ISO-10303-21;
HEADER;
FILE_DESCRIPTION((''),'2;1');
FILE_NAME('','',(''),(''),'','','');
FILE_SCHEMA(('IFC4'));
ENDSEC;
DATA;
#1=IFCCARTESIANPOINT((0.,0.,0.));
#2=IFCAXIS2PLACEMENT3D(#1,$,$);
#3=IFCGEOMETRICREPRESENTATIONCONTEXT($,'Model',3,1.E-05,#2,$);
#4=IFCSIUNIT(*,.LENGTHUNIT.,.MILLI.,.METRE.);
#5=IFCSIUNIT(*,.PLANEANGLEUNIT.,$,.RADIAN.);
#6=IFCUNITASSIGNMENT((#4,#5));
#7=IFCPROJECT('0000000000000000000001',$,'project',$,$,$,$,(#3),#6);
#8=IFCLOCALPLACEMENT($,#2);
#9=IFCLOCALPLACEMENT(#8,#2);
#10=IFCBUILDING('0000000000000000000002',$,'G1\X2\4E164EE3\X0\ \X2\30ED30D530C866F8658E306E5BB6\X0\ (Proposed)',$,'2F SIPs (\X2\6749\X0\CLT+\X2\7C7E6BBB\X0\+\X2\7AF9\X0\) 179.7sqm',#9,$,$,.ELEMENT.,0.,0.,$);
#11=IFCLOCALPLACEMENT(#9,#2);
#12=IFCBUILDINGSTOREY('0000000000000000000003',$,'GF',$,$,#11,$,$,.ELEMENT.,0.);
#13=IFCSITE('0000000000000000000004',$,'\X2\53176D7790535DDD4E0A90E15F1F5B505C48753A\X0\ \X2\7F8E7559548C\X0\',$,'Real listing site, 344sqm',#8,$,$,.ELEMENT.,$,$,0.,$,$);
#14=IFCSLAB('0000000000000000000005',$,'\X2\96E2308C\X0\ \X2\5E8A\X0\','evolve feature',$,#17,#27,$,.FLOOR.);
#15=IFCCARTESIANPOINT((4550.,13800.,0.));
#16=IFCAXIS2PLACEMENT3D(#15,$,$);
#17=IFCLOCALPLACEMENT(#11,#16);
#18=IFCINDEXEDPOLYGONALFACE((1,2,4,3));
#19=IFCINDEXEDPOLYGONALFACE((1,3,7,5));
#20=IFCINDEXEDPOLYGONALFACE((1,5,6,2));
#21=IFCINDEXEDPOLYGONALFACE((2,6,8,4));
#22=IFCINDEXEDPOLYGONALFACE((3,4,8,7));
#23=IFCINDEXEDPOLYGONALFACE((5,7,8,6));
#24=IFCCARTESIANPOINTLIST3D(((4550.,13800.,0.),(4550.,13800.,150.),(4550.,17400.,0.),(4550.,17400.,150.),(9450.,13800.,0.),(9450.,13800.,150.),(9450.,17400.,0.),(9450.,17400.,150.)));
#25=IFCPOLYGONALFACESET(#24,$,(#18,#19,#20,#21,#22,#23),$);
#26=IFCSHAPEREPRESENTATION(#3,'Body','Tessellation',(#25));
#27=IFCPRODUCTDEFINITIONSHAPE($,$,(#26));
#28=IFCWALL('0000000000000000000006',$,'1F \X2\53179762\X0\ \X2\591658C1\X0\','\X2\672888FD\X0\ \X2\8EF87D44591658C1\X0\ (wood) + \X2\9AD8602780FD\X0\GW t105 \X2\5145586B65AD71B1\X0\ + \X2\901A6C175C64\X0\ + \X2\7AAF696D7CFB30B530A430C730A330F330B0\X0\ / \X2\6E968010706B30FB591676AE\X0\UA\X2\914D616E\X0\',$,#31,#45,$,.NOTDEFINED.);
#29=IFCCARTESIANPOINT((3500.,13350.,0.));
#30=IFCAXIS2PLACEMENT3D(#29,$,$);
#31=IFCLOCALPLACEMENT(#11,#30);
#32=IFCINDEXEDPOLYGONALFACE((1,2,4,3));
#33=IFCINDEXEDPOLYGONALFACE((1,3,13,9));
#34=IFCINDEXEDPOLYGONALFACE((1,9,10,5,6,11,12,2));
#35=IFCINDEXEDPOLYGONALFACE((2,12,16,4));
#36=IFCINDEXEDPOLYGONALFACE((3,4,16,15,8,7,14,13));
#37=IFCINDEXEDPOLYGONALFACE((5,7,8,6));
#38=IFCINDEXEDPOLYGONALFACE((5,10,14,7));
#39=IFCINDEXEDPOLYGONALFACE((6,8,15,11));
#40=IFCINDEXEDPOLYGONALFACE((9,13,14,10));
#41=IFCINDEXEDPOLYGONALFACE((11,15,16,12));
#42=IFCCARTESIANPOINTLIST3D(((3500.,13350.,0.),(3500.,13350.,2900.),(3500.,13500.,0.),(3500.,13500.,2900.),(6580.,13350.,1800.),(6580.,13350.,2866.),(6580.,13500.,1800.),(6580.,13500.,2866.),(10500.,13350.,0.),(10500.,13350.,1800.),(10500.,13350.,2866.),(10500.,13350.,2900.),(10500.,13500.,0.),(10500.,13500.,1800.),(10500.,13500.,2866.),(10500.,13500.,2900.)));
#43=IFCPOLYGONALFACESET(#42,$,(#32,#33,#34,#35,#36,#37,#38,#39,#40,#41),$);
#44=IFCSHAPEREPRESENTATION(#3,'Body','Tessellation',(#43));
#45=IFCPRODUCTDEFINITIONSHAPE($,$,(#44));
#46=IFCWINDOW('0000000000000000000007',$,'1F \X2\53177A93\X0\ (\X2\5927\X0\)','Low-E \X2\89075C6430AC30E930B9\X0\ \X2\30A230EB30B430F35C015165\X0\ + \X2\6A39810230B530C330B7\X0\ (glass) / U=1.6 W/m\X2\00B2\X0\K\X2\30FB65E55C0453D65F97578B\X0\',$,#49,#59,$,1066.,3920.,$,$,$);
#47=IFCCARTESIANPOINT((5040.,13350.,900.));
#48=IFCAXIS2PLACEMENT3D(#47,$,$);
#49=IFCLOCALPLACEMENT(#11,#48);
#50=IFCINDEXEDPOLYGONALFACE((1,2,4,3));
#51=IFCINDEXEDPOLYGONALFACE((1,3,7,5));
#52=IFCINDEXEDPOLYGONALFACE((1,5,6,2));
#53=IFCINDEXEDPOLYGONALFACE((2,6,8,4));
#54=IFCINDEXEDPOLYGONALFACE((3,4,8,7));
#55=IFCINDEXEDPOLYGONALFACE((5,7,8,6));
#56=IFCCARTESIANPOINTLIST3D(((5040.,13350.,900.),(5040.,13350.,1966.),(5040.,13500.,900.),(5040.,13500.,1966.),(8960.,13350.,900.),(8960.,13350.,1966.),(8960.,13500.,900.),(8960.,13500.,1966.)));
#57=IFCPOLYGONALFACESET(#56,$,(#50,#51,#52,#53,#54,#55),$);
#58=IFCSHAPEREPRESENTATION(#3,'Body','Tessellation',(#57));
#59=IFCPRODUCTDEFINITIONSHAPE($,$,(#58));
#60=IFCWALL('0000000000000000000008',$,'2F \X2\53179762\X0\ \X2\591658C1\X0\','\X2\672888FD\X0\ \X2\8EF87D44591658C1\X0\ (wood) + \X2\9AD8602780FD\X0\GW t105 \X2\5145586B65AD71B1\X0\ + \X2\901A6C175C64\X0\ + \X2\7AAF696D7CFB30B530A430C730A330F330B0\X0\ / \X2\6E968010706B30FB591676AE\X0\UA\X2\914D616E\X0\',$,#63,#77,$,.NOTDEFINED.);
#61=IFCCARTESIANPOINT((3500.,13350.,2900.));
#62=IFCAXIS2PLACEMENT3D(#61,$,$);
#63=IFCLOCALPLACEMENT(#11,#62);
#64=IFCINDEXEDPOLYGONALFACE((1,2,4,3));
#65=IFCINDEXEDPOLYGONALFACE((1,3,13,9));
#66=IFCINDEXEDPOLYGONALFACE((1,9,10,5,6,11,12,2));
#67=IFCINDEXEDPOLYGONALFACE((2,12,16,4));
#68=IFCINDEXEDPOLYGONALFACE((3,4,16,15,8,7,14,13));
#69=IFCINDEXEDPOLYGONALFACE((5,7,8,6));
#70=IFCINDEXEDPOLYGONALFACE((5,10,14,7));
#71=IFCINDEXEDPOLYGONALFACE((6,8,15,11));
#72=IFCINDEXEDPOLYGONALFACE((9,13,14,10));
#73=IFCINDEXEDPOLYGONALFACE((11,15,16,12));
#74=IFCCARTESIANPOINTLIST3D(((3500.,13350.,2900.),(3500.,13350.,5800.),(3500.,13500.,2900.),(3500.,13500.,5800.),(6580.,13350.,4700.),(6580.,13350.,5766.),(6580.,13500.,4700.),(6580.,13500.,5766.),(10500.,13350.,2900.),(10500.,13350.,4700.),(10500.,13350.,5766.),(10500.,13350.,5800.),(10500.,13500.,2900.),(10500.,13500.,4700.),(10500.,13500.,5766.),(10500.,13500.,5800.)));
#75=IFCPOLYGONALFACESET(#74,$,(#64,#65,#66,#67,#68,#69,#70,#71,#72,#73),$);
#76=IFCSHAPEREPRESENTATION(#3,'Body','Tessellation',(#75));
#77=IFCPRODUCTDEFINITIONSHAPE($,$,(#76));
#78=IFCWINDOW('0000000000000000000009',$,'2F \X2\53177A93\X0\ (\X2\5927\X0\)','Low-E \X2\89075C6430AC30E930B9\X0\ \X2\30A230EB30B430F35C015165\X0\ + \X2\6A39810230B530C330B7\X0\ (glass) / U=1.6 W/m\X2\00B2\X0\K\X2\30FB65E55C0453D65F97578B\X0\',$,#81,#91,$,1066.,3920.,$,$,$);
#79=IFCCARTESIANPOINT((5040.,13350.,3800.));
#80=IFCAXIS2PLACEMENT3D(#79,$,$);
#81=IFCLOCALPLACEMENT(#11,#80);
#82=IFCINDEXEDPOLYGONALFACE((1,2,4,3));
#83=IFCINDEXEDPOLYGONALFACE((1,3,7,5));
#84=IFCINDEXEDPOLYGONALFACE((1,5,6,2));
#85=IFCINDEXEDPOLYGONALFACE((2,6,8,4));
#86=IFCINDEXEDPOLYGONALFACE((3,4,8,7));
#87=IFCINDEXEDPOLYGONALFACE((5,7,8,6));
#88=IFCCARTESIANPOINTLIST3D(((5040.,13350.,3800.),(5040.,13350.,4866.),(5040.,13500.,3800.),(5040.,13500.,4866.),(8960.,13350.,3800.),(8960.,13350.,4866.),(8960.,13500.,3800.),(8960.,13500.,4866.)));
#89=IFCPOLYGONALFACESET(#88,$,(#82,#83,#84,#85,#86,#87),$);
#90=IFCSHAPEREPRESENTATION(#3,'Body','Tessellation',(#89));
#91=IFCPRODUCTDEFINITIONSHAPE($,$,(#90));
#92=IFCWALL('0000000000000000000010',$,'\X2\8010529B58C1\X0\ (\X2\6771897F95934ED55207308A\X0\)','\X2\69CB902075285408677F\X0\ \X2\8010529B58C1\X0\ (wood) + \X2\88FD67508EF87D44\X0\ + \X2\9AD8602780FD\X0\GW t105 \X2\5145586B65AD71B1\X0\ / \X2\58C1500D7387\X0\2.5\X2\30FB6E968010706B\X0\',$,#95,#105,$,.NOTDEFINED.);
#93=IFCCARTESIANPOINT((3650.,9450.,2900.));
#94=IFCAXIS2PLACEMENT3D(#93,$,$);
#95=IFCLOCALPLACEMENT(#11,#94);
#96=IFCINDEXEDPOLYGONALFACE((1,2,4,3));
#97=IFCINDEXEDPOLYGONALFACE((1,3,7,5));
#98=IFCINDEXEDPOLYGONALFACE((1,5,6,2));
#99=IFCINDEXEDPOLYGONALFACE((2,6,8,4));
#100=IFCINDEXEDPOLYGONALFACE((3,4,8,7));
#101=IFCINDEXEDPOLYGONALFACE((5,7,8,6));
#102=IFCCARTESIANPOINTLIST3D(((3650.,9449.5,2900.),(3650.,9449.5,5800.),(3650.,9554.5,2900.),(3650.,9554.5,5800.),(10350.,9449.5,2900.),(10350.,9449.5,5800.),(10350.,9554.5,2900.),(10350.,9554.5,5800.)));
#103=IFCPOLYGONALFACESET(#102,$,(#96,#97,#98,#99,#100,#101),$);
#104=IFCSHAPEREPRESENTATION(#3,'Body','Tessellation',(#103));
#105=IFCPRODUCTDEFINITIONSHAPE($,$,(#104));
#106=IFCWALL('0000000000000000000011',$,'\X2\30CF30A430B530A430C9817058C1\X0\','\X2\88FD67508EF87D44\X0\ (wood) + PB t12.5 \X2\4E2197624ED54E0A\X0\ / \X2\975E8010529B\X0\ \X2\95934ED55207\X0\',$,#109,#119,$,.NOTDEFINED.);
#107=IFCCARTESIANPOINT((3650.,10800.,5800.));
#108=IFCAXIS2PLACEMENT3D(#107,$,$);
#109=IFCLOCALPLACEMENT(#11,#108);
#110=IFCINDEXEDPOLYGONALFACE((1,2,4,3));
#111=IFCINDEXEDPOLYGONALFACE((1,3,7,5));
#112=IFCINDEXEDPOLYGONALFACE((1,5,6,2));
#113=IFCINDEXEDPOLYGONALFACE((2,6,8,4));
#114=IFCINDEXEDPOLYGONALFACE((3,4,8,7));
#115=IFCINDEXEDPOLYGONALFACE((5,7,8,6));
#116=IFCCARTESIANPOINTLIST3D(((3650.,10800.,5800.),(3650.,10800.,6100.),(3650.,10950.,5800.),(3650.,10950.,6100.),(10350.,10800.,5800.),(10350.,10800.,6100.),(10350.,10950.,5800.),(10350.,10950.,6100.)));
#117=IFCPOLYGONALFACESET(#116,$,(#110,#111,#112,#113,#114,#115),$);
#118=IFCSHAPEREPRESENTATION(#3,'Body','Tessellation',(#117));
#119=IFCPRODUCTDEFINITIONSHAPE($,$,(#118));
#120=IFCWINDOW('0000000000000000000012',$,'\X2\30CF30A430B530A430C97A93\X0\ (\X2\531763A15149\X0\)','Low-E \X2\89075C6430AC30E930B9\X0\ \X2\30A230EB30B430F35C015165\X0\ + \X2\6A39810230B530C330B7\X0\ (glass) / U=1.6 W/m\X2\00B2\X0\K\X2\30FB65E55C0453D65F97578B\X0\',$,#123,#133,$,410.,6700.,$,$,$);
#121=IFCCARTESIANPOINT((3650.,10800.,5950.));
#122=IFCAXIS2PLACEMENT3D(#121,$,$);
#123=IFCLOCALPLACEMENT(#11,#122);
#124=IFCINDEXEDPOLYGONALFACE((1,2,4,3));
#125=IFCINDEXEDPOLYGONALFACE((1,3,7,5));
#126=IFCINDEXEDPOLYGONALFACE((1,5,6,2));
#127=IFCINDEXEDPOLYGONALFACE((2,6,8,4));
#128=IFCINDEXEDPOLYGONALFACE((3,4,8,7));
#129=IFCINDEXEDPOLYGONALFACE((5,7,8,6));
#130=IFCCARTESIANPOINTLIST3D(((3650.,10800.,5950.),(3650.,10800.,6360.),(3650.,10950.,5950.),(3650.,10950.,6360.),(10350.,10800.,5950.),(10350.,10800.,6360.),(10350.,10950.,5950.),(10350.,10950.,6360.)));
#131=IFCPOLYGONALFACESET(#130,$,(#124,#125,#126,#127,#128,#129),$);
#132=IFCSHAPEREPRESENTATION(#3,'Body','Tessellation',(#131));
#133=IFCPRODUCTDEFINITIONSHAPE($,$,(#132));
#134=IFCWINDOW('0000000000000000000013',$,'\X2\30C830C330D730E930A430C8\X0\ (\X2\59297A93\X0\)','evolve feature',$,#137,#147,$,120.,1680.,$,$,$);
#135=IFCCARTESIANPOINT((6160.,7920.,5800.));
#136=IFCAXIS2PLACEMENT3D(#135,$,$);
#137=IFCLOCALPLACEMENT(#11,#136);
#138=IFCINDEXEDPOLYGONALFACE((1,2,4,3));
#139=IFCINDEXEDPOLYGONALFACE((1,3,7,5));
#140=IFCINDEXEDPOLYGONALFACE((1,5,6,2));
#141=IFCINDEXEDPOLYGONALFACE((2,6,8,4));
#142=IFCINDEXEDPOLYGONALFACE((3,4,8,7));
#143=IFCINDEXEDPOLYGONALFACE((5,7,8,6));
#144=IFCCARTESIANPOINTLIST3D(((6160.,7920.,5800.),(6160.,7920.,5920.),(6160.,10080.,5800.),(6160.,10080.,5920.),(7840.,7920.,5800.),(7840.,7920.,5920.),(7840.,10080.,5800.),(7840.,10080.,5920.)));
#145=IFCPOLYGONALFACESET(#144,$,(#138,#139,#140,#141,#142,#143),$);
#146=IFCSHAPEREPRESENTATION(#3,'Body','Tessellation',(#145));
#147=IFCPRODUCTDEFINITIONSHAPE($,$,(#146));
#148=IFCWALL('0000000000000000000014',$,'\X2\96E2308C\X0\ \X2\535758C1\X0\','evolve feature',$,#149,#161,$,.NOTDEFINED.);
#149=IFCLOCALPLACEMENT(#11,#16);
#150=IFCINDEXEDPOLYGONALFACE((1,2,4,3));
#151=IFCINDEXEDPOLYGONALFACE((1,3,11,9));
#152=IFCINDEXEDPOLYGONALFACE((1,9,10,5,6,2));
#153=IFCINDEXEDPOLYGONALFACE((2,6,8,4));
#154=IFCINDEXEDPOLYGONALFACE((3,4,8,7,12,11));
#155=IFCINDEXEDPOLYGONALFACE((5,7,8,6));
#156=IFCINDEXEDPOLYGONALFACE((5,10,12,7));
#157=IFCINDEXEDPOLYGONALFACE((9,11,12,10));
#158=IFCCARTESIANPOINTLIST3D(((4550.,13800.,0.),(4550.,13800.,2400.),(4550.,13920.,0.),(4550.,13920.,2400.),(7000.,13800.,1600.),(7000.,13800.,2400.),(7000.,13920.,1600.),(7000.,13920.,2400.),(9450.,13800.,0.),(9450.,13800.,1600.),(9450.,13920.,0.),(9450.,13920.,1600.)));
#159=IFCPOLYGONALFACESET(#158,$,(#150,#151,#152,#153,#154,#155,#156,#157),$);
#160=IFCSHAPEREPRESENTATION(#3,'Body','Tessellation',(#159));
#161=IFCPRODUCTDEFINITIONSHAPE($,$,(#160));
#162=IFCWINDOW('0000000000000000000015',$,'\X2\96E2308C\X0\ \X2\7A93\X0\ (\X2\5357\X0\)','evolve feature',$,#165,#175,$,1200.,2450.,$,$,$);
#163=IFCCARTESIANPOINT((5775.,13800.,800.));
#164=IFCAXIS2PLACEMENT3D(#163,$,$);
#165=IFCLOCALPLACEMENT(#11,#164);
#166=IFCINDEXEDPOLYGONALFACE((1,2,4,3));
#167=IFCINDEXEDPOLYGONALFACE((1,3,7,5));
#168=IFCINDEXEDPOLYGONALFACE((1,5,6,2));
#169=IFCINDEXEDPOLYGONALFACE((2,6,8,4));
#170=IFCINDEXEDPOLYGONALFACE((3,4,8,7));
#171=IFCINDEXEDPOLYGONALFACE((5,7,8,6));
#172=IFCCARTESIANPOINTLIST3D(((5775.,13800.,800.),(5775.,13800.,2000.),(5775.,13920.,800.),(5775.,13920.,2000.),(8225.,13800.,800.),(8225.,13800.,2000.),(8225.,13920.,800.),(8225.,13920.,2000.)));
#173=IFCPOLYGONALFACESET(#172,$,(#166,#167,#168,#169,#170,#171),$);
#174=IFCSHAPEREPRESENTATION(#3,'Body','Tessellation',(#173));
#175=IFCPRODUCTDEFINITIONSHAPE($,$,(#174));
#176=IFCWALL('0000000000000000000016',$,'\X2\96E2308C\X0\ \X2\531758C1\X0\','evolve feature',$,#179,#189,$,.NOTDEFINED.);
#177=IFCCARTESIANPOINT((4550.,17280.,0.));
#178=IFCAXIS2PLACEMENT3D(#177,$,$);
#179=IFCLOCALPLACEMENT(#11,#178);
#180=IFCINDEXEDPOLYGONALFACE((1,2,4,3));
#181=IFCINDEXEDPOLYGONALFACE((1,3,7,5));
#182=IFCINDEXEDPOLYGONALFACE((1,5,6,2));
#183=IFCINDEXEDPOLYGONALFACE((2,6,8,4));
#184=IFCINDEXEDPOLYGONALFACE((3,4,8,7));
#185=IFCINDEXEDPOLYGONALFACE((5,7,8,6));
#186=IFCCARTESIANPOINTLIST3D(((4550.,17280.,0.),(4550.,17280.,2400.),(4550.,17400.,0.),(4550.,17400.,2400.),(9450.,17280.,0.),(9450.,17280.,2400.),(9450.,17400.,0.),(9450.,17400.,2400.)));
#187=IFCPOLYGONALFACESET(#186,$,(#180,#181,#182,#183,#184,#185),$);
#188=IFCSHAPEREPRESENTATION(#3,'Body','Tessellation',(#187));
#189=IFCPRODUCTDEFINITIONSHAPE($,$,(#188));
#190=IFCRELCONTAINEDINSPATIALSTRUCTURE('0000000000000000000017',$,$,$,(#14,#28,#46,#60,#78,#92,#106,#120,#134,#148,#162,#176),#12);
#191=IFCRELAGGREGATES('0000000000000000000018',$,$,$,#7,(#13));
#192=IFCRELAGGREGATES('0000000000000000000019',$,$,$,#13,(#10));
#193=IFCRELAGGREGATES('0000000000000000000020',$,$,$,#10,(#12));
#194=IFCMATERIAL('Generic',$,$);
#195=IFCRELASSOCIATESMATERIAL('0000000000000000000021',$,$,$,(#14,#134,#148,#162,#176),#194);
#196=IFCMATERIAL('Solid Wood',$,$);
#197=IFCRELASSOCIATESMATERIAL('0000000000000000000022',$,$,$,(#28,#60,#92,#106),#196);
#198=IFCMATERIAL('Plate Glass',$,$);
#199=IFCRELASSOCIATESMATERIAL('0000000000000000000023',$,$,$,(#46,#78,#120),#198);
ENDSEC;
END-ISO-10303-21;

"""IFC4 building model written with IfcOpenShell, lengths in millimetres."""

from ifc_helpers import new_model, si_unit, frame, frame_2d, origin, place, context, project, spatial, rectangle, extrude, material, element, fill, save


model = new_model("IFC4")

# Units and contexts
model_context = context("Model", 3, precision=1e-05, world=origin())
ifc_project = project(units=[si_unit("LENGTHUNIT", "METRE", prefix="MILLI"), si_unit("PLANEANGLEUNIT", "RADIAN")], contexts=[model_context])

# Site, building, storey
site_placement = place(None, origin())
site = spatial("IfcSite", under=ifc_project, at=site_placement, Name="北海道川上郡弟子屈町 美留和", ObjectType="Real listing site, 344sqm", CompositionType="ELEMENT", RefElevation=0.0)
building_placement = place(site_placement, origin())
building = spatial("IfcBuilding", under=site, at=building_placement, Name="G1世代 ロフト書斎の家 (Proposed)", ObjectType="2F SIPs (杉CLT+籾殻+竹) 179.7sqm", CompositionType="ELEMENT", ElevationOfRefHeight=0.0, ElevationOfTerrain=0.0)
storey_placement = place(building_placement, origin())
storey = spatial("IfcBuildingStorey", under=building, at=storey_placement, Name="GF", CompositionType="ELEMENT", Elevation=0.0)

# Slab
ifc_material_1 = material(Name="Generic")
slab_placement = place(storey_placement, frame((4550.0, 13800.0, 0.0)))
element("IfcSlab", 1, at=slab_placement, inside=storey, material=ifc_material_1, Name="離れ 床", Description="evolve feature", PredefinedType="FLOOR", context=model_context, shape_type="SweptSolid", body=[
    extrude(rectangle(XDim=4900.0, YDim=3600.0, at=frame_2d((2450.0, 1800.0))), frame((4550.0, 13800.0, 0.0)), (0.0, 0.0, 1.0), 150.0),
])

# Wall, opening, window
ifc_material_2 = material(Name="Solid Wood")
wall_1_placement = place(storey_placement, frame((3500.0, 13350.0, 0.0)))
wall_1 = element("IfcWall", 2, at=wall_1_placement, inside=storey, material=ifc_material_2, Name="1F 北面 外壁", Description="木製 軸組外壁 (wood) + 高性能GW t105 充填断熱 + 通気層 + 窯業系サイディング / 準耐火・外皮UA配慮", PredefinedType="NOTDEFINED", context=model_context, shape_type="SweptSolid", body=[
    extrude(rectangle(XDim=7000.0, YDim=150.0, at=frame_2d((3500.0, 75.0))), frame((3500.0, 13350.0, 0.0)), (0.0, 0.0, 1.0), 2900.0),
])
opening_1_placement = place(storey_placement, frame((5040.0, 13350.0, 900.0)))
opening_1 = element("IfcOpeningElement", 3, at=opening_1_placement, cuts=wall_1, PredefinedType="NOTDEFINED", context=model_context, shape_type="SweptSolid", body=[
    extrude(rectangle(XDim=3920.0, YDim=150.0, at=frame_2d((1960.0, 75.0))), frame((5040.0, 13350.0, 900.0)), (0.0, 0.0, 1.0), 1066.0),
])
ifc_material_3 = material(Name="Plate Glass")
window_1_placement = place(storey_placement, frame((5040.0, 13350.0, 900.0)))
window_1 = element("IfcWindow", 4, at=window_1_placement, inside=storey, material=ifc_material_3, Name="1F 北窓 (大)", Description="Low-E 複層ガラス アルゴン封入 + 樹脂サッシ (glass) / U=1.6 W/m²K・日射取得型", OverallHeight=1066.0, OverallWidth=3920.0, context=model_context, shape_type="SweptSolid", body=[
    extrude(rectangle(XDim=3920.0, YDim=150.0, at=frame_2d((1960.0, 75.0))), frame((5040.0, 13350.0, 900.0)), (0.0, 0.0, 1.0), 1066.0),
])
fill(opening_1, window_1)

# Wall, opening, window
wall_2_placement = place(storey_placement, frame((3500.0, 13350.0, 2900.0)))
wall_2 = element("IfcWall", 5, at=wall_2_placement, inside=storey, material=ifc_material_2, Name="2F 北面 外壁", Description="木製 軸組外壁 (wood) + 高性能GW t105 充填断熱 + 通気層 + 窯業系サイディング / 準耐火・外皮UA配慮", PredefinedType="NOTDEFINED", context=model_context, shape_type="SweptSolid", body=[
    extrude(rectangle(XDim=7000.0, YDim=150.0, at=frame_2d((3500.0, 75.0))), frame((3500.0, 13350.0, 2900.0)), (0.0, 0.0, 1.0), 2900.0),
])
opening_2_placement = place(storey_placement, frame((5040.0, 13350.0, 3800.0)))
opening_2 = element("IfcOpeningElement", 6, at=opening_2_placement, cuts=wall_2, PredefinedType="NOTDEFINED", context=model_context, shape_type="SweptSolid", body=[
    extrude(rectangle(XDim=3920.0, YDim=150.0, at=frame_2d((1960.0, 75.0))), frame((5040.0, 13350.0, 3800.0)), (0.0, 0.0, 1.0), 1066.0),
])
window_2_placement = place(storey_placement, frame((5040.0, 13350.0, 3800.0)))
window_2 = element("IfcWindow", 7, at=window_2_placement, inside=storey, material=ifc_material_3, Name="2F 北窓 (大)", Description="Low-E 複層ガラス アルゴン封入 + 樹脂サッシ (glass) / U=1.6 W/m²K・日射取得型", OverallHeight=1066.0, OverallWidth=3920.0, context=model_context, shape_type="SweptSolid", body=[
    extrude(rectangle(XDim=3920.0, YDim=150.0, at=frame_2d((1960.0, 75.0))), frame((5040.0, 13350.0, 3800.0)), (0.0, 0.0, 1.0), 1066.0),
])
fill(opening_2, window_2)

# Wall
wall_3_placement = place(storey_placement, frame((3650.0, 9450.0, 2900.0)))
element("IfcWall", 8, at=wall_3_placement, inside=storey, material=ifc_material_2, Name="耐力壁 (東西間仕切り)", Description="構造用合板 耐力壁 (wood) + 製材軸組 + 高性能GW t105 充填断熱 / 壁倍率2.5・準耐火", PredefinedType="NOTDEFINED", context=model_context, shape_type="SweptSolid", body=[
    extrude(rectangle(XDim=6700.0, YDim=105.0, at=frame_2d((3350.0, 52.0))), frame((3650.0, 9450.0, 2900.0)), (0.0, 0.0, 1.0), 2900.0),
])

# Wall, opening, window
wall_4_placement = place(storey_placement, frame((3650.0, 10800.0, 5800.0)))
wall_4 = element("IfcWall", 9, at=wall_4_placement, inside=storey, material=ifc_material_2, Name="ハイサイド腰壁", Description="製材軸組 (wood) + PB t12.5 両面仕上 / 非耐力 間仕切", PredefinedType="NOTDEFINED", context=model_context, shape_type="SweptSolid", body=[
    extrude(rectangle(XDim=6700.0, YDim=150.0, at=frame_2d((3350.0, 75.0))), frame((3650.0, 10800.0, 5800.0)), (0.0, 0.0, 1.0), 700.0),
])
opening_3_placement = place(storey_placement, frame((3650.0, 10800.0, 5950.0)))
opening_3 = element("IfcOpeningElement", 10, at=opening_3_placement, cuts=wall_4, PredefinedType="NOTDEFINED", context=model_context, shape_type="SweptSolid", body=[
    extrude(rectangle(XDim=6700.0, YDim=150.0, at=frame_2d((3350.0, 75.0))), frame((3650.0, 10800.0, 5950.0)), (0.0, 0.0, 1.0), 410.0),
])
window_3_placement = place(storey_placement, frame((3650.0, 10800.0, 5950.0)))
window_3 = element("IfcWindow", 11, at=window_3_placement, inside=storey, material=ifc_material_3, Name="ハイサイド窓 (北採光)", Description="Low-E 複層ガラス アルゴン封入 + 樹脂サッシ (glass) / U=1.6 W/m²K・日射取得型", OverallHeight=410.0, OverallWidth=6700.0, context=model_context, shape_type="SweptSolid", body=[
    extrude(rectangle(XDim=6700.0, YDim=150.0, at=frame_2d((3350.0, 75.0))), frame((3650.0, 10800.0, 5950.0)), (0.0, 0.0, 1.0), 410.0),
])
fill(opening_3, window_3)

# Window
window_4_placement = place(storey_placement, frame((6160.0, 7920.0, 5800.0)))
element("IfcWindow", 12, at=window_4_placement, inside=storey, material=ifc_material_1, Name="トップライト (天窓)", Description="evolve feature", OverallHeight=120.0, OverallWidth=1680.0, context=model_context, shape_type="SweptSolid", body=[
    extrude(rectangle(XDim=1680.0, YDim=2160.0, at=frame_2d((840.0, 1080.0))), frame((6160.0, 7920.0, 5800.0)), (0.0, 0.0, 1.0), 120.0),
])

# Wall, opening, window
wall_5_placement = place(storey_placement, frame((4550.0, 13800.0, 0.0)))
wall_5 = element("IfcWall", 13, at=wall_5_placement, inside=storey, material=ifc_material_1, Name="離れ 南壁", Description="evolve feature", PredefinedType="NOTDEFINED", context=model_context, shape_type="SweptSolid", body=[
    extrude(rectangle(XDim=4900.0, YDim=120.0, at=frame_2d((2450.0, 60.0))), frame((4550.0, 13800.0, 0.0)), (0.0, 0.0, 1.0), 2400.0),
])
opening_4_placement = place(storey_placement, frame((5775.0, 13800.0, 800.0)))
opening_4 = element("IfcOpeningElement", 14, at=opening_4_placement, cuts=wall_5, PredefinedType="NOTDEFINED", context=model_context, shape_type="SweptSolid", body=[
    extrude(rectangle(XDim=2450.0, YDim=120.0, at=frame_2d((1225.0, 60.0))), frame((5775.0, 13800.0, 800.0)), (0.0, 0.0, 1.0), 1200.0),
])
window_5_placement = place(storey_placement, frame((5775.0, 13800.0, 800.0)))
window_5 = element("IfcWindow", 15, at=window_5_placement, inside=storey, material=ifc_material_1, Name="離れ 窓 (南)", Description="evolve feature", OverallHeight=1200.0, OverallWidth=2450.0, context=model_context, shape_type="SweptSolid", body=[
    extrude(rectangle(XDim=2450.0, YDim=120.0, at=frame_2d((1225.0, 60.0))), frame((5775.0, 13800.0, 800.0)), (0.0, 0.0, 1.0), 1200.0),
])
fill(opening_4, window_5)

# Wall
wall_6_placement = place(storey_placement, frame((4550.0, 17280.0, 0.0)))
element("IfcWall", 16, at=wall_6_placement, inside=storey, material=ifc_material_1, Name="離れ 北壁", Description="evolve feature", PredefinedType="NOTDEFINED", context=model_context, shape_type="SweptSolid", body=[
    extrude(rectangle(XDim=4900.0, YDim=120.0, at=frame_2d((2450.0, 60.0))), frame((4550.0, 17280.0, 0.0)), (0.0, 0.0, 1.0), 2400.0),
])

save(model, "model.ifc")
